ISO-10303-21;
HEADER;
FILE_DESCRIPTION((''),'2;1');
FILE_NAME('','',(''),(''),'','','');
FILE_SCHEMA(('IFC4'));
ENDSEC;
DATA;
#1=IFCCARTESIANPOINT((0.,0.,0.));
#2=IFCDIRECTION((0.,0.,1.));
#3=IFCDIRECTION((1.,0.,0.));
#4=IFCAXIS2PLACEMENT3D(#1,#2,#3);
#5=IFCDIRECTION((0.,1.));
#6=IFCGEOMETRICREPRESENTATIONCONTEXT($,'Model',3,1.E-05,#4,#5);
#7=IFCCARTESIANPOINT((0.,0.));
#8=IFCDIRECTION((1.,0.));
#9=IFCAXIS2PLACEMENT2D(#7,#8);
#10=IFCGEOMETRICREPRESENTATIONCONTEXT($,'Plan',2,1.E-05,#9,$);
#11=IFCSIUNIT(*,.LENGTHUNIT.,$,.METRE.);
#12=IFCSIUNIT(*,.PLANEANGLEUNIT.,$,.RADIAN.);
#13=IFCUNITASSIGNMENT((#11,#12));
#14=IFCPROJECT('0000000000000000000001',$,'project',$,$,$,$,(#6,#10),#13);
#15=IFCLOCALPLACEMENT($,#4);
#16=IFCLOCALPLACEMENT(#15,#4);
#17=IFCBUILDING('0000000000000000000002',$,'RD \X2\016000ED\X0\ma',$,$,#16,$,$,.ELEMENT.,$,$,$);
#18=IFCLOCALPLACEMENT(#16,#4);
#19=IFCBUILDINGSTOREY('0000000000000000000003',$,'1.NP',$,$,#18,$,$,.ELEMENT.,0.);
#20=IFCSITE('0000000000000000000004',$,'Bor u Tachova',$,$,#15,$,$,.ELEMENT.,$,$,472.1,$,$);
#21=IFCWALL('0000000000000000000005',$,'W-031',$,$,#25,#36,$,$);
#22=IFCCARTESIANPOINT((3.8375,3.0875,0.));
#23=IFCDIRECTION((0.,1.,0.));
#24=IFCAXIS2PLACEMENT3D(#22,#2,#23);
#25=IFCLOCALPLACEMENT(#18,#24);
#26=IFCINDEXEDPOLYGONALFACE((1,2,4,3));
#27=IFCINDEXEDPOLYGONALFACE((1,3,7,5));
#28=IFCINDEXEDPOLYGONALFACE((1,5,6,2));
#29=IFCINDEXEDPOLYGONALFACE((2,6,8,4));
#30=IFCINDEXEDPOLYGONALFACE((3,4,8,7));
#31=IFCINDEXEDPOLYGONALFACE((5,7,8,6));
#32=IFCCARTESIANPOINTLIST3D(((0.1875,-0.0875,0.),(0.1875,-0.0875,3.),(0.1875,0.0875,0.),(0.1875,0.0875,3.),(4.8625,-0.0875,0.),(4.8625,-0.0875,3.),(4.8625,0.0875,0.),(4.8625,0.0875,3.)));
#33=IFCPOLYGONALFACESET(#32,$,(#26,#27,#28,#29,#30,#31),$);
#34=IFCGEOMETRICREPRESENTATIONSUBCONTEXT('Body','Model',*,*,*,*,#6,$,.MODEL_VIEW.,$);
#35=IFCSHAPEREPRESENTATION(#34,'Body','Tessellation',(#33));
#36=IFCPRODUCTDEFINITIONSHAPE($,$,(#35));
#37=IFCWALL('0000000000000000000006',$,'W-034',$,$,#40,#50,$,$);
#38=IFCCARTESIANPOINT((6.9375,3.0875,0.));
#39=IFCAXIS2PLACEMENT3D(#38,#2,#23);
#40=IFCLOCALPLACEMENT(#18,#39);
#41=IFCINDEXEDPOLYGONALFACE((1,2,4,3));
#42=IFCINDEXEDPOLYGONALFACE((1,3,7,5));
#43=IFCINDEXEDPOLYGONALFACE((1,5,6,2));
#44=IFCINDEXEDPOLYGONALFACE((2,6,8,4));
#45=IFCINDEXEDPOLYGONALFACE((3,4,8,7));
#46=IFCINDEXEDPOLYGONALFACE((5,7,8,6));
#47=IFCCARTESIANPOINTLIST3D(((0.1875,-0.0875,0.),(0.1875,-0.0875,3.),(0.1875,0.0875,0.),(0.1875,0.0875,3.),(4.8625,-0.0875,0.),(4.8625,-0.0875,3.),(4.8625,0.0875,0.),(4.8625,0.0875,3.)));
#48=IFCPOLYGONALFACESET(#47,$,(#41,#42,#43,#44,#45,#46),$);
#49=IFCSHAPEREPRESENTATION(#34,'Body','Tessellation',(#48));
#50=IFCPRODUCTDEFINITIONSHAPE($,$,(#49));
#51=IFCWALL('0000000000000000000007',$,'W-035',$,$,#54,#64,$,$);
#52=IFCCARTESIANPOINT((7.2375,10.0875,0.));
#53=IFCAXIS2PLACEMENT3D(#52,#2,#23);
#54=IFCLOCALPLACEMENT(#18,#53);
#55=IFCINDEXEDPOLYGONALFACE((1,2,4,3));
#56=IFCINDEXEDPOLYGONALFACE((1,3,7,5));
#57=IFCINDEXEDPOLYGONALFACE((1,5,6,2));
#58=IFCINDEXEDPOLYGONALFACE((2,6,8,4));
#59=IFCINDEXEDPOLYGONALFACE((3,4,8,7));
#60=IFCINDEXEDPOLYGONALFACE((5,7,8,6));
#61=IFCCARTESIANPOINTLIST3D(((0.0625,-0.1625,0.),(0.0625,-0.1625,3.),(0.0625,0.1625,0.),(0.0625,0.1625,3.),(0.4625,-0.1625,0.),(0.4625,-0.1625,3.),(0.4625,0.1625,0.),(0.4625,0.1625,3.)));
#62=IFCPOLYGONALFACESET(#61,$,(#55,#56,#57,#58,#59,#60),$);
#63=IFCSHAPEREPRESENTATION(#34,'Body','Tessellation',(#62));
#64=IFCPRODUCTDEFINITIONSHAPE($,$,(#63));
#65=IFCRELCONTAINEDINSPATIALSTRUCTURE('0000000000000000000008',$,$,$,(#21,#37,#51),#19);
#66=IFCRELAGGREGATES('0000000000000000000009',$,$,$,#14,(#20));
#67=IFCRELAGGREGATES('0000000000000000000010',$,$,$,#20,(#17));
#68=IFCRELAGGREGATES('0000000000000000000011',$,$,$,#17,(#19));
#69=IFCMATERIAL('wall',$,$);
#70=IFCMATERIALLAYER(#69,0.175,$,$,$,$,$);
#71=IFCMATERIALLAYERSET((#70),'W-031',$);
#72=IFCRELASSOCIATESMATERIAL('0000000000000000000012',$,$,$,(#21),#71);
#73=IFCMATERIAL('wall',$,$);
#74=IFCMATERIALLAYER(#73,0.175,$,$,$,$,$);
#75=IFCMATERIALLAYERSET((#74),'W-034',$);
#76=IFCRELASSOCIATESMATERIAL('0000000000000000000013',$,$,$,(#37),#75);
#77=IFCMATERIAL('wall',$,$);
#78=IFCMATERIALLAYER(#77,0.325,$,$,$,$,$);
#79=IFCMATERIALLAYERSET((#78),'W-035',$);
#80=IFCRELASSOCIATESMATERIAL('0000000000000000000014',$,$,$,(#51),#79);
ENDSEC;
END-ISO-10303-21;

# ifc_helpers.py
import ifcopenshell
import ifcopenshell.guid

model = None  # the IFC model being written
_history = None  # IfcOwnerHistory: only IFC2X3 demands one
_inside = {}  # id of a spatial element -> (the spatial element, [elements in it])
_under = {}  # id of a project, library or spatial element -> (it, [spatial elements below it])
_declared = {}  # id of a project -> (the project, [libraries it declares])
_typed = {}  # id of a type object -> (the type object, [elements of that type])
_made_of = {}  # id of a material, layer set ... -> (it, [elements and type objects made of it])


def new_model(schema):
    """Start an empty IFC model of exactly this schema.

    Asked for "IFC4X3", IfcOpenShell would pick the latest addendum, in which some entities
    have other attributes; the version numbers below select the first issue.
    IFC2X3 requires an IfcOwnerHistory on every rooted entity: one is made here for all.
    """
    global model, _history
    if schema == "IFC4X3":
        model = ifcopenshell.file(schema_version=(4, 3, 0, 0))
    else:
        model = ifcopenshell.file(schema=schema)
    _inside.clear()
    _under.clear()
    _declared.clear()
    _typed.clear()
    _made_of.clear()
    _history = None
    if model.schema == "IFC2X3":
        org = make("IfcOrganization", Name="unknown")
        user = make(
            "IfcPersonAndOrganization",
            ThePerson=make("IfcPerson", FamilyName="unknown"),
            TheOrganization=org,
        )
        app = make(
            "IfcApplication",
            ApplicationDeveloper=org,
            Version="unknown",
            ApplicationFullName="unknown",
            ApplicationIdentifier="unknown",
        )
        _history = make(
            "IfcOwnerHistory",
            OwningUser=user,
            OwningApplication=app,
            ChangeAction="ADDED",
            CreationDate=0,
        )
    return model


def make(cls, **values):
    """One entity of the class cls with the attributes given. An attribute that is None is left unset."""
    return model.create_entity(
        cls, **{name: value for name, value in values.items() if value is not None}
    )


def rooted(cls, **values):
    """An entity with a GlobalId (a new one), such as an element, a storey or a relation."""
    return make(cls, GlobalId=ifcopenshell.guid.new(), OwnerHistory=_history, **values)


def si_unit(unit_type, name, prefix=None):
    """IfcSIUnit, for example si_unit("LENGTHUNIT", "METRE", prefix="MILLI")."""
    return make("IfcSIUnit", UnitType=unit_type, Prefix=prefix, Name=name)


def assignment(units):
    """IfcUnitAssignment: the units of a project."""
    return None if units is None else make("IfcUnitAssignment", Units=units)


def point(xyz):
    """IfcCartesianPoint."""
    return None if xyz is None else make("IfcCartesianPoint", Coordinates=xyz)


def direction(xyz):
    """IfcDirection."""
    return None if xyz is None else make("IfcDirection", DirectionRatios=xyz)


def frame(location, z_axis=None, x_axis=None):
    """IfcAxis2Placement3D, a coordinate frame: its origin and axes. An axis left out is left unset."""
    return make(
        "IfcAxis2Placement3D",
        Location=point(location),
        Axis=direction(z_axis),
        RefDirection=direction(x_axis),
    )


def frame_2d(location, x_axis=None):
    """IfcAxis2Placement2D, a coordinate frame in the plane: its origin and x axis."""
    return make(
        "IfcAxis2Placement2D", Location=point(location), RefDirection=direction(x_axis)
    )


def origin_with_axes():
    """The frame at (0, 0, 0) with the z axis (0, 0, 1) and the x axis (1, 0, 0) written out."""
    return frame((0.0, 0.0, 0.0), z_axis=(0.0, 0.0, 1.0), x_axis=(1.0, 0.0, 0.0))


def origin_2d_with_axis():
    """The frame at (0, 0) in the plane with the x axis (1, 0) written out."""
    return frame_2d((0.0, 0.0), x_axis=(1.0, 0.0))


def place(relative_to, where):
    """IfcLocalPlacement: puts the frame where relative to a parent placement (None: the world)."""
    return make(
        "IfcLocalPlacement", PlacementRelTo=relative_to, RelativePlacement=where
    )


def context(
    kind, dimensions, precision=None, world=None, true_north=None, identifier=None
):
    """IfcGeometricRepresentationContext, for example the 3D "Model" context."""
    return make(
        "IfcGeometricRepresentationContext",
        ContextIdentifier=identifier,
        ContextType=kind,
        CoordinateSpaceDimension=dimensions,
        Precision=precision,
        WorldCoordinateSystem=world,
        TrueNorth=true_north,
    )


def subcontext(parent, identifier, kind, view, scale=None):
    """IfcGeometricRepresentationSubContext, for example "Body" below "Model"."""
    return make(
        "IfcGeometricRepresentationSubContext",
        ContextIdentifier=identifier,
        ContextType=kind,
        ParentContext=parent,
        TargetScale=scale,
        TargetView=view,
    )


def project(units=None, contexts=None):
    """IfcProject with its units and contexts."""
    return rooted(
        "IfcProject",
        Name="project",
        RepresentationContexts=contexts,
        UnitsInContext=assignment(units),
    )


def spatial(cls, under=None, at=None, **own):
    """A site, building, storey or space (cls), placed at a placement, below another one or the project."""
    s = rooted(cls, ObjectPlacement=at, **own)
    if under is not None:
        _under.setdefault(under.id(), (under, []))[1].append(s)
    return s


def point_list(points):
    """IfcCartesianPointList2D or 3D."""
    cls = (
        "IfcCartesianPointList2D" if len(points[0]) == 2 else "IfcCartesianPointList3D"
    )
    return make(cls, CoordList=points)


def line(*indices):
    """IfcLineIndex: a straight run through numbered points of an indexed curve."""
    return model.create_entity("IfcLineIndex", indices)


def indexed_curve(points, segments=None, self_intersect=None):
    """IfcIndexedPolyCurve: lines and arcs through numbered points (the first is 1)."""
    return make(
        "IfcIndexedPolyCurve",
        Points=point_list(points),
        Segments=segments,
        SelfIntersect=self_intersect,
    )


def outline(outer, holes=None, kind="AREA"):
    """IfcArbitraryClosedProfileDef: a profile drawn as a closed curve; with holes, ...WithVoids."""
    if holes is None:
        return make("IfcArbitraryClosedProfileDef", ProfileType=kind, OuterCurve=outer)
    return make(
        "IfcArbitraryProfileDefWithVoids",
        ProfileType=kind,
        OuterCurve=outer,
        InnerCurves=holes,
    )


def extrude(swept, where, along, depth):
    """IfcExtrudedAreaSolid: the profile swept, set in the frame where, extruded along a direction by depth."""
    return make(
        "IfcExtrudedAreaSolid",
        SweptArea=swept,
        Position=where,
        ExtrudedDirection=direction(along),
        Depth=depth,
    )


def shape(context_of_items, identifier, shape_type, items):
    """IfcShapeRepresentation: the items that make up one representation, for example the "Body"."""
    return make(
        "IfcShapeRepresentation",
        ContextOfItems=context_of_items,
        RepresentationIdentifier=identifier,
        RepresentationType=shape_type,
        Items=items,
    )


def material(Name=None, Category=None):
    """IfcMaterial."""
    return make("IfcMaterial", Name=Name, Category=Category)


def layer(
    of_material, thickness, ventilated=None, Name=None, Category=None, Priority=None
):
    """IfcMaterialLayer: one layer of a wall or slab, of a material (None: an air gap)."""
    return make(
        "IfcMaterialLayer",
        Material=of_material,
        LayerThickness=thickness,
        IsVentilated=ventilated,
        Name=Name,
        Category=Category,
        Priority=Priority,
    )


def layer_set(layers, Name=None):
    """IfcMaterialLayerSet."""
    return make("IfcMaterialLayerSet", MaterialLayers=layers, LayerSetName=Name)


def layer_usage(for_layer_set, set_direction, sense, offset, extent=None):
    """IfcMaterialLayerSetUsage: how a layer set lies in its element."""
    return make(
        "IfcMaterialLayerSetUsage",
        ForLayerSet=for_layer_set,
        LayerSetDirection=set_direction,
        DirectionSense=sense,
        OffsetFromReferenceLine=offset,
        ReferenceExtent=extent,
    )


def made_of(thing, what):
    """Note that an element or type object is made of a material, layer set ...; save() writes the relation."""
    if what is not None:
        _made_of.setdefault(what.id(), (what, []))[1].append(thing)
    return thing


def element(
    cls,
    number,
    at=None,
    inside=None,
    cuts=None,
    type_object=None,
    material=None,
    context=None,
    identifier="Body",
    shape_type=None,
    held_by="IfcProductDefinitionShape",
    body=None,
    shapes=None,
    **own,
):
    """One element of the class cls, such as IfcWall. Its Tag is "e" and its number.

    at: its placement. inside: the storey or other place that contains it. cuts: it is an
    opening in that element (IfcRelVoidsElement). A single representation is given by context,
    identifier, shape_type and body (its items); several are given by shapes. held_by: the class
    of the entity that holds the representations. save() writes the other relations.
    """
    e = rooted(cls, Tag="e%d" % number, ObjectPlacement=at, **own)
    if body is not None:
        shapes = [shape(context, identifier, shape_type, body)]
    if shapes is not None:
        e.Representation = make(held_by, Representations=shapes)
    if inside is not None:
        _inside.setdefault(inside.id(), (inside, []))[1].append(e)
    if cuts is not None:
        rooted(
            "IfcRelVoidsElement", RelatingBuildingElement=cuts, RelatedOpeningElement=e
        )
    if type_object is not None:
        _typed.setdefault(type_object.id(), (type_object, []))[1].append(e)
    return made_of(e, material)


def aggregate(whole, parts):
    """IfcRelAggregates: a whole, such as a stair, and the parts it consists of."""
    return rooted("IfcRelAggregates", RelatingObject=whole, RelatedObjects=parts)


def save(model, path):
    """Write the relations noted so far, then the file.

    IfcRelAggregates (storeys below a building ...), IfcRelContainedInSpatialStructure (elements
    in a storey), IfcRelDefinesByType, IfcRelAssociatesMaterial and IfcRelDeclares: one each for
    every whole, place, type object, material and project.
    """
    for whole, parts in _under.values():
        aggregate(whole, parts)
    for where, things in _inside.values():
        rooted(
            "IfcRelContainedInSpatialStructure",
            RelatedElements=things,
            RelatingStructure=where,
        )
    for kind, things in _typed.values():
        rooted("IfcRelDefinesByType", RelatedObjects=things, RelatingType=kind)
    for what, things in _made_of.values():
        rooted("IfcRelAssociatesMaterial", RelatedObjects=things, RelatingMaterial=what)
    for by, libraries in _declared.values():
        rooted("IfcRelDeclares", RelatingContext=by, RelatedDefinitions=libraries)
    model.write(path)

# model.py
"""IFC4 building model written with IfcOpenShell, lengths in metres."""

from ifc_helpers import new_model, si_unit, direction, frame, origin_with_axes, origin_2d_with_axis, place, context, subcontext, project, spatial, line, indexed_curve, outline, extrude, material, layer, layer_set, layer_usage, element, save


model = new_model("IFC4")

# Units and contexts
model_context = context("Model", 3, precision=1e-05, world=origin_with_axes(), true_north=direction((0.0, 1.0)))
plan_context = context("Plan", 2, precision=1e-05, world=origin_2d_with_axis())
body_context = subcontext(model_context, "Body", "Model", "MODEL_VIEW")
ifc_project = project(units=[si_unit("LENGTHUNIT", "METRE"), si_unit("PLANEANGLEUNIT", "RADIAN")], contexts=[model_context, plan_context])

# Site, building, storey
site_placement = place(None, origin_with_axes())
site = spatial("IfcSite", under=ifc_project, at=site_placement, Name="Bor u Tachova", CompositionType="ELEMENT", RefElevation=472.1)
building_placement = place(site_placement, origin_with_axes())
building = spatial("IfcBuilding", under=site, at=building_placement, Name="RD Šíma", CompositionType="ELEMENT")
storey_placement = place(building_placement, origin_with_axes())
storey = spatial("IfcBuildingStorey", under=building, at=storey_placement, Name="1.NP", CompositionType="ELEMENT", Elevation=0.0)

# Wall
ifc_material_1 = material(Name="wall")
ifc_layer_1 = layer(ifc_material_1, 0.175)
ifc_layer_set_1 = layer_set([ifc_layer_1], Name="W-031")
ifc_layer_usage_1 = layer_usage(ifc_layer_set_1, "AXIS2", "POSITIVE", -0.0875)
wall_1_placement = place(storey_placement, frame((3.8375, 3.0875, 0.0), z_axis=(0.0, 0.0, 1.0), x_axis=(0.0, 1.0, 0.0)))
element("IfcWall", 1, at=wall_1_placement, inside=storey, material=ifc_layer_usage_1, Name="W-031", context=body_context, shape_type="SweptSolid", body=[
    extrude(outline(indexed_curve([(0.1875, -0.0875), (0.1875, 0.0875), (4.8625, 0.0875), (4.8625, -0.0875)], segments=[line(1, 2, 3, 4, 1)])), origin_with_axes(), (0.0, 0.0, 1.0), 3.0),
])

# Walls
ifc_material_2 = material(Name="wall")
ifc_layer_2 = layer(ifc_material_2, 0.175)
ifc_layer_set_2 = layer_set([ifc_layer_2], Name="W-034")
ifc_layer_usage_2 = layer_usage(ifc_layer_set_2, "AXIS2", "POSITIVE", -0.0875)
wall_2_placement = place(storey_placement, frame((6.9375, 3.0875, 0.0), z_axis=(0.0, 0.0, 1.0), x_axis=(0.0, 1.0, 0.0)))
element("IfcWall", 2, at=wall_2_placement, inside=storey, material=ifc_layer_usage_2, Name="W-034", context=body_context, shape_type="SweptSolid", body=[
    extrude(outline(indexed_curve([(0.1875, -0.0875), (0.1875, 0.0875), (4.8625, 0.0875), (4.8625, -0.0875)], segments=[line(1, 2, 3, 4, 1)])), origin_with_axes(), (0.0, 0.0, 1.0), 3.0),
])
ifc_material_3 = material(Name="wall")
ifc_layer_3 = layer(ifc_material_3, 0.325)
ifc_layer_set_3 = layer_set([ifc_layer_3], Name="W-035")
ifc_layer_usage_3 = layer_usage(ifc_layer_set_3, "AXIS2", "POSITIVE", -0.1625)
wall_3_placement = place(storey_placement, frame((7.2375, 10.0875, 0.0), z_axis=(0.0, 0.0, 1.0), x_axis=(0.0, 1.0, 0.0)))
element("IfcWall", 3, at=wall_3_placement, inside=storey, material=ifc_layer_usage_3, Name="W-035", context=body_context, shape_type="SweptSolid", body=[
    extrude(outline(indexed_curve([(0.0625, -0.1625), (0.0625, 0.1625), (0.4625, 0.1625), (0.4625, -0.1625)], segments=[line(1, 2, 3, 4, 1)])), origin_with_axes(), (0.0, 0.0, 1.0), 3.0),
])

save(model, "model.ifc")
